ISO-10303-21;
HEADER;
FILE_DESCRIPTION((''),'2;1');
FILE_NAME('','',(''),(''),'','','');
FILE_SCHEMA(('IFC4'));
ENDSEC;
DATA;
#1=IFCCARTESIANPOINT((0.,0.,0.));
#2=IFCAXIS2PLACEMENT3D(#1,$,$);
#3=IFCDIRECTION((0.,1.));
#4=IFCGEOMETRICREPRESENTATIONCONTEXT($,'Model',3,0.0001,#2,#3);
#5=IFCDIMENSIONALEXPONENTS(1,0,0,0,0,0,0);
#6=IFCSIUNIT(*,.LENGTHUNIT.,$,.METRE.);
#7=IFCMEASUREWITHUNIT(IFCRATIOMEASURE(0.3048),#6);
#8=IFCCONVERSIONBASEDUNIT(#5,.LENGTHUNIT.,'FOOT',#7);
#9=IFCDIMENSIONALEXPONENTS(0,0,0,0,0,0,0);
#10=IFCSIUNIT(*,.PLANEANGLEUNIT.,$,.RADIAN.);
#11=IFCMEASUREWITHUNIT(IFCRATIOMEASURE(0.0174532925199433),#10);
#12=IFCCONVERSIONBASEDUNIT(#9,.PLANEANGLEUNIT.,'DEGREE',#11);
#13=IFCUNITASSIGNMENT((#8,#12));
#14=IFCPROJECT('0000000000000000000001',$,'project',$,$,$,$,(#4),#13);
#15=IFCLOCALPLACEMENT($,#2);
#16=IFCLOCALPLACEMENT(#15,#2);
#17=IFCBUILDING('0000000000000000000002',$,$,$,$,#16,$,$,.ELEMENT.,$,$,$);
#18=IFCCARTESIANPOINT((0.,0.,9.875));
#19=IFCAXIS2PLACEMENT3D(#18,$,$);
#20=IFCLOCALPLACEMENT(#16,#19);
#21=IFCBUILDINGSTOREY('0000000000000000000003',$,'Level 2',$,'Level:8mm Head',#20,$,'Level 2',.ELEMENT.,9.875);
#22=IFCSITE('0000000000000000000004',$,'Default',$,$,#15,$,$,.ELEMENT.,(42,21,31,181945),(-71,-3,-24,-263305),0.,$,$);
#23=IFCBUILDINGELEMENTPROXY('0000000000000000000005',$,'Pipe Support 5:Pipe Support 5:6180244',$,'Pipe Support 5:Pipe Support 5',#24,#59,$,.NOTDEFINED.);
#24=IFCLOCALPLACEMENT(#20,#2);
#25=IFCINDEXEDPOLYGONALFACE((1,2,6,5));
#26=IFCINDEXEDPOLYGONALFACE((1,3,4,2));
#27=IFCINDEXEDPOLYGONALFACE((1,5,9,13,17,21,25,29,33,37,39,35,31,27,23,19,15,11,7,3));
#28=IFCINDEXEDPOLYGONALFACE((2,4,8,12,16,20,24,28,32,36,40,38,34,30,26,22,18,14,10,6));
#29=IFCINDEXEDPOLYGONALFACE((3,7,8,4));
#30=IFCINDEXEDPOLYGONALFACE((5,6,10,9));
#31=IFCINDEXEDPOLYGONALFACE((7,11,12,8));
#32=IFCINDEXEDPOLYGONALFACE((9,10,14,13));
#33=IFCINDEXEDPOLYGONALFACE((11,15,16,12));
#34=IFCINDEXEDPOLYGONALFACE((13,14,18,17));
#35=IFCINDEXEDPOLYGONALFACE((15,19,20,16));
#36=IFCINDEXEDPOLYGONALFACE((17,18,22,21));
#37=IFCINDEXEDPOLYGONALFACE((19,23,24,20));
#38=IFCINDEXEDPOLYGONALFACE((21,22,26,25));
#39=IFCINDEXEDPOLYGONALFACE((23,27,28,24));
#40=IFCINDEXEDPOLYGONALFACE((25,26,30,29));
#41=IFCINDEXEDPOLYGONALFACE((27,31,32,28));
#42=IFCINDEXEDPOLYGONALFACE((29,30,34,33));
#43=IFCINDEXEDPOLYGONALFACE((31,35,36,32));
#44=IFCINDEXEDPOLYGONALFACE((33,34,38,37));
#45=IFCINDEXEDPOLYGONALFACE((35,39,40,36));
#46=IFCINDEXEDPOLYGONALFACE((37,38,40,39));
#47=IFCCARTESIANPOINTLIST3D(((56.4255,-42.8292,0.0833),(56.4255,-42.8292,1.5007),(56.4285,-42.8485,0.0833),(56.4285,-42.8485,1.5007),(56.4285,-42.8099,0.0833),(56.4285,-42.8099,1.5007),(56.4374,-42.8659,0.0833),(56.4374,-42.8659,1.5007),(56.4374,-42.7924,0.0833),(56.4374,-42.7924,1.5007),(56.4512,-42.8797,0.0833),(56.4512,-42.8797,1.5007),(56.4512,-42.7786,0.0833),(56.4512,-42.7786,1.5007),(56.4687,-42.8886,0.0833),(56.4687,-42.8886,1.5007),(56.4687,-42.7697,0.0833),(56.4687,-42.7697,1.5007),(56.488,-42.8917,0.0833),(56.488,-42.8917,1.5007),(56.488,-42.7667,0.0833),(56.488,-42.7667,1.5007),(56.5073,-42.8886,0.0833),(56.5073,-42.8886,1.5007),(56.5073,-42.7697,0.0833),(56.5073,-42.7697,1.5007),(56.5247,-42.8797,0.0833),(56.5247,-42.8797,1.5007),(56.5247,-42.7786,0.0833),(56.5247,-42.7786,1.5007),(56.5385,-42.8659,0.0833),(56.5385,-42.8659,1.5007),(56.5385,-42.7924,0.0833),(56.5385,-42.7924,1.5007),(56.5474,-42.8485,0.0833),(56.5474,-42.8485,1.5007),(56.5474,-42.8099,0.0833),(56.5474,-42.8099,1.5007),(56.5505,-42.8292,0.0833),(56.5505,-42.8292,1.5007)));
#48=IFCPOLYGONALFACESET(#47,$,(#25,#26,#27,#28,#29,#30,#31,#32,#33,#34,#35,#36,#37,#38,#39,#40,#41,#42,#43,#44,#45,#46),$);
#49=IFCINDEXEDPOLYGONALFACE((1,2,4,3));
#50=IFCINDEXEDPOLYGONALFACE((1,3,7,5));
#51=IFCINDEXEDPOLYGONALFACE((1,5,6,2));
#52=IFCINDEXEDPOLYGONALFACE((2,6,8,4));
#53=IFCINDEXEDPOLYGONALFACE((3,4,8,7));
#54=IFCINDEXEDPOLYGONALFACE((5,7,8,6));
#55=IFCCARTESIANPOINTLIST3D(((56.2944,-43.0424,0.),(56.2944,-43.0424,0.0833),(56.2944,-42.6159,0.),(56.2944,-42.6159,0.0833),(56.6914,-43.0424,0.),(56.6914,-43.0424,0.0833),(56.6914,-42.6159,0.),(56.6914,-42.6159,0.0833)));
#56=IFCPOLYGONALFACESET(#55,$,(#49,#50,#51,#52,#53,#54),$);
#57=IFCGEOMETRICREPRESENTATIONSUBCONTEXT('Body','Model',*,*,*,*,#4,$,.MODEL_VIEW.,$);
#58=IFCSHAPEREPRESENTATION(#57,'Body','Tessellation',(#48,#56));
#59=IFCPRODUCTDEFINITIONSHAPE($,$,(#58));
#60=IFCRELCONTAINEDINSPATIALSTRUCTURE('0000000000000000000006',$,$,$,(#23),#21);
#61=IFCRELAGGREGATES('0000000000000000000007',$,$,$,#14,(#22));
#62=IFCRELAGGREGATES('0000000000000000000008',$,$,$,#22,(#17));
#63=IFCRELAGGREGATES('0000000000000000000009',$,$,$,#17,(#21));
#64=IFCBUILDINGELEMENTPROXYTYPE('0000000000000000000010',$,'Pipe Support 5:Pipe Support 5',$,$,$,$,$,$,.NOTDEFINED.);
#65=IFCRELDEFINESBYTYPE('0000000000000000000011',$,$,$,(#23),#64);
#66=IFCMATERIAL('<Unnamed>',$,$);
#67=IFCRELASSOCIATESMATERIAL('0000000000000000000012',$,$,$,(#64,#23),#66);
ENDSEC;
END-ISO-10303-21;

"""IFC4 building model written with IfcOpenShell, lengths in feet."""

from ifc_helpers import new_model, entity, si_unit, converted_unit, direction, frame, origin, place, context, subcontext, project, spatial, indexed_curve, outline, extrude, source, transform, mapped, material, type_object, type_shapes, element, save


model = new_model("IFC4")

# Units and contexts
model_context = context("Model", 3, precision=0.0001, world=origin(), true_north=direction((0.0, 1.0)))
body_context = subcontext(model_context, "Body", "Model", "MODEL_VIEW")
ifc_project = project(units=[converted_unit("LENGTHUNIT", "FOOT", entity("IfcRatioMeasure", 0.3048), si_unit("LENGTHUNIT", "METRE"), dimensions=[1, 0, 0, 0, 0, 0, 0]), converted_unit("PLANEANGLEUNIT", "DEGREE", entity("IfcRatioMeasure", 0.0174532925199433), si_unit("PLANEANGLEUNIT", "RADIAN"), dimensions=[0, 0, 0, 0, 0, 0, 0])], contexts=[model_context])

# Site, building, storey
site_placement = place(None, origin())
site = spatial("IfcSite", under=ifc_project, at=site_placement, Name="Default", CompositionType="ELEMENT", RefLatitude=(42, 21, 31, 181945), RefLongitude=(-71, -3, -24, -263305), RefElevation=0.0)
building_placement = place(site_placement, origin())
building = spatial("IfcBuilding", under=site, at=building_placement, CompositionType="ELEMENT")
storey_placement = place(building_placement, frame((0.0, 0.0, 9.875)))
storey = spatial("IfcBuildingStorey", under=building, at=storey_placement, Name="Level 2", ObjectType="Level:8mm Head", LongName="Level 2", CompositionType="ELEMENT", Elevation=9.875)

# Shared definitions
ifc_material_1 = material(Name="<Unnamed>")

# Building element proxy
building_element_proxy_type_1 = type_object("IfcBuildingElementProxyType", Name="Pipe Support 5:Pipe Support 5", PredefinedType="NOTDEFINED", material=ifc_material_1)
shared_shape_1 = source(origin(), body_context, "Body", "SweptSolid", [
    extrude(outline(indexed_curve([(0.0625, 0.0), (0.0594, 0.0193), (0.0506, 0.0367), (0.0367, 0.0506), (0.0193, 0.0594), (0.0, 0.0625), (-0.0193, 0.0594), (-0.0367, 0.0506), (-0.0506, 0.0367), (-0.0594, 0.0193), (-0.0625, 0.0), (-0.0594, -0.0193), (-0.0506, -0.0367), (-0.0367, -0.0506), (-0.0193, -0.0594), (0.0, -0.0625), (0.0193, -0.0594), (0.0367, -0.0506), (0.0506, -0.0367), (0.0594, -0.0193), (0.0625, 0.0)], self_intersect=False)), frame((-0.0049, 0.0, 0.0833)), (0.0, 0.0, 1.0), 1.4174),
    extrude(outline(indexed_curve([(-0.1985, -0.2133), (0.1985, -0.2133), (0.1985, 0.2133), (-0.1985, 0.2133), (-0.1985, -0.2133)], self_intersect=False)), frame((0.0, 0.0, 0.0), z_axis=(0.0, 0.0, 1.0), x_axis=(-1.0, 0.0, 0.0)), (0.0, 0.0, 1.0), 0.0833),
])
type_shapes(building_element_proxy_type_1, [shared_shape_1])
for number, where, name in (
    (1, (56.4929, -42.8292, 0.0), "Pipe Support 5:Pipe Support 5:6180244"),
):
    element("IfcBuildingElementProxy", number, at=place(storey_placement, frame(where)), inside=storey, type_object=building_element_proxy_type_1, material=ifc_material_1, Name=name, ObjectType="Pipe Support 5:Pipe Support 5", PredefinedType="NOTDEFINED", context=body_context, shape_type="MappedRepresentation", body=[
        mapped(shared_shape_1, transform((0.0, 0.0, 0.0), scale=1.0)),
    ])

save(model, "model.ifc")
